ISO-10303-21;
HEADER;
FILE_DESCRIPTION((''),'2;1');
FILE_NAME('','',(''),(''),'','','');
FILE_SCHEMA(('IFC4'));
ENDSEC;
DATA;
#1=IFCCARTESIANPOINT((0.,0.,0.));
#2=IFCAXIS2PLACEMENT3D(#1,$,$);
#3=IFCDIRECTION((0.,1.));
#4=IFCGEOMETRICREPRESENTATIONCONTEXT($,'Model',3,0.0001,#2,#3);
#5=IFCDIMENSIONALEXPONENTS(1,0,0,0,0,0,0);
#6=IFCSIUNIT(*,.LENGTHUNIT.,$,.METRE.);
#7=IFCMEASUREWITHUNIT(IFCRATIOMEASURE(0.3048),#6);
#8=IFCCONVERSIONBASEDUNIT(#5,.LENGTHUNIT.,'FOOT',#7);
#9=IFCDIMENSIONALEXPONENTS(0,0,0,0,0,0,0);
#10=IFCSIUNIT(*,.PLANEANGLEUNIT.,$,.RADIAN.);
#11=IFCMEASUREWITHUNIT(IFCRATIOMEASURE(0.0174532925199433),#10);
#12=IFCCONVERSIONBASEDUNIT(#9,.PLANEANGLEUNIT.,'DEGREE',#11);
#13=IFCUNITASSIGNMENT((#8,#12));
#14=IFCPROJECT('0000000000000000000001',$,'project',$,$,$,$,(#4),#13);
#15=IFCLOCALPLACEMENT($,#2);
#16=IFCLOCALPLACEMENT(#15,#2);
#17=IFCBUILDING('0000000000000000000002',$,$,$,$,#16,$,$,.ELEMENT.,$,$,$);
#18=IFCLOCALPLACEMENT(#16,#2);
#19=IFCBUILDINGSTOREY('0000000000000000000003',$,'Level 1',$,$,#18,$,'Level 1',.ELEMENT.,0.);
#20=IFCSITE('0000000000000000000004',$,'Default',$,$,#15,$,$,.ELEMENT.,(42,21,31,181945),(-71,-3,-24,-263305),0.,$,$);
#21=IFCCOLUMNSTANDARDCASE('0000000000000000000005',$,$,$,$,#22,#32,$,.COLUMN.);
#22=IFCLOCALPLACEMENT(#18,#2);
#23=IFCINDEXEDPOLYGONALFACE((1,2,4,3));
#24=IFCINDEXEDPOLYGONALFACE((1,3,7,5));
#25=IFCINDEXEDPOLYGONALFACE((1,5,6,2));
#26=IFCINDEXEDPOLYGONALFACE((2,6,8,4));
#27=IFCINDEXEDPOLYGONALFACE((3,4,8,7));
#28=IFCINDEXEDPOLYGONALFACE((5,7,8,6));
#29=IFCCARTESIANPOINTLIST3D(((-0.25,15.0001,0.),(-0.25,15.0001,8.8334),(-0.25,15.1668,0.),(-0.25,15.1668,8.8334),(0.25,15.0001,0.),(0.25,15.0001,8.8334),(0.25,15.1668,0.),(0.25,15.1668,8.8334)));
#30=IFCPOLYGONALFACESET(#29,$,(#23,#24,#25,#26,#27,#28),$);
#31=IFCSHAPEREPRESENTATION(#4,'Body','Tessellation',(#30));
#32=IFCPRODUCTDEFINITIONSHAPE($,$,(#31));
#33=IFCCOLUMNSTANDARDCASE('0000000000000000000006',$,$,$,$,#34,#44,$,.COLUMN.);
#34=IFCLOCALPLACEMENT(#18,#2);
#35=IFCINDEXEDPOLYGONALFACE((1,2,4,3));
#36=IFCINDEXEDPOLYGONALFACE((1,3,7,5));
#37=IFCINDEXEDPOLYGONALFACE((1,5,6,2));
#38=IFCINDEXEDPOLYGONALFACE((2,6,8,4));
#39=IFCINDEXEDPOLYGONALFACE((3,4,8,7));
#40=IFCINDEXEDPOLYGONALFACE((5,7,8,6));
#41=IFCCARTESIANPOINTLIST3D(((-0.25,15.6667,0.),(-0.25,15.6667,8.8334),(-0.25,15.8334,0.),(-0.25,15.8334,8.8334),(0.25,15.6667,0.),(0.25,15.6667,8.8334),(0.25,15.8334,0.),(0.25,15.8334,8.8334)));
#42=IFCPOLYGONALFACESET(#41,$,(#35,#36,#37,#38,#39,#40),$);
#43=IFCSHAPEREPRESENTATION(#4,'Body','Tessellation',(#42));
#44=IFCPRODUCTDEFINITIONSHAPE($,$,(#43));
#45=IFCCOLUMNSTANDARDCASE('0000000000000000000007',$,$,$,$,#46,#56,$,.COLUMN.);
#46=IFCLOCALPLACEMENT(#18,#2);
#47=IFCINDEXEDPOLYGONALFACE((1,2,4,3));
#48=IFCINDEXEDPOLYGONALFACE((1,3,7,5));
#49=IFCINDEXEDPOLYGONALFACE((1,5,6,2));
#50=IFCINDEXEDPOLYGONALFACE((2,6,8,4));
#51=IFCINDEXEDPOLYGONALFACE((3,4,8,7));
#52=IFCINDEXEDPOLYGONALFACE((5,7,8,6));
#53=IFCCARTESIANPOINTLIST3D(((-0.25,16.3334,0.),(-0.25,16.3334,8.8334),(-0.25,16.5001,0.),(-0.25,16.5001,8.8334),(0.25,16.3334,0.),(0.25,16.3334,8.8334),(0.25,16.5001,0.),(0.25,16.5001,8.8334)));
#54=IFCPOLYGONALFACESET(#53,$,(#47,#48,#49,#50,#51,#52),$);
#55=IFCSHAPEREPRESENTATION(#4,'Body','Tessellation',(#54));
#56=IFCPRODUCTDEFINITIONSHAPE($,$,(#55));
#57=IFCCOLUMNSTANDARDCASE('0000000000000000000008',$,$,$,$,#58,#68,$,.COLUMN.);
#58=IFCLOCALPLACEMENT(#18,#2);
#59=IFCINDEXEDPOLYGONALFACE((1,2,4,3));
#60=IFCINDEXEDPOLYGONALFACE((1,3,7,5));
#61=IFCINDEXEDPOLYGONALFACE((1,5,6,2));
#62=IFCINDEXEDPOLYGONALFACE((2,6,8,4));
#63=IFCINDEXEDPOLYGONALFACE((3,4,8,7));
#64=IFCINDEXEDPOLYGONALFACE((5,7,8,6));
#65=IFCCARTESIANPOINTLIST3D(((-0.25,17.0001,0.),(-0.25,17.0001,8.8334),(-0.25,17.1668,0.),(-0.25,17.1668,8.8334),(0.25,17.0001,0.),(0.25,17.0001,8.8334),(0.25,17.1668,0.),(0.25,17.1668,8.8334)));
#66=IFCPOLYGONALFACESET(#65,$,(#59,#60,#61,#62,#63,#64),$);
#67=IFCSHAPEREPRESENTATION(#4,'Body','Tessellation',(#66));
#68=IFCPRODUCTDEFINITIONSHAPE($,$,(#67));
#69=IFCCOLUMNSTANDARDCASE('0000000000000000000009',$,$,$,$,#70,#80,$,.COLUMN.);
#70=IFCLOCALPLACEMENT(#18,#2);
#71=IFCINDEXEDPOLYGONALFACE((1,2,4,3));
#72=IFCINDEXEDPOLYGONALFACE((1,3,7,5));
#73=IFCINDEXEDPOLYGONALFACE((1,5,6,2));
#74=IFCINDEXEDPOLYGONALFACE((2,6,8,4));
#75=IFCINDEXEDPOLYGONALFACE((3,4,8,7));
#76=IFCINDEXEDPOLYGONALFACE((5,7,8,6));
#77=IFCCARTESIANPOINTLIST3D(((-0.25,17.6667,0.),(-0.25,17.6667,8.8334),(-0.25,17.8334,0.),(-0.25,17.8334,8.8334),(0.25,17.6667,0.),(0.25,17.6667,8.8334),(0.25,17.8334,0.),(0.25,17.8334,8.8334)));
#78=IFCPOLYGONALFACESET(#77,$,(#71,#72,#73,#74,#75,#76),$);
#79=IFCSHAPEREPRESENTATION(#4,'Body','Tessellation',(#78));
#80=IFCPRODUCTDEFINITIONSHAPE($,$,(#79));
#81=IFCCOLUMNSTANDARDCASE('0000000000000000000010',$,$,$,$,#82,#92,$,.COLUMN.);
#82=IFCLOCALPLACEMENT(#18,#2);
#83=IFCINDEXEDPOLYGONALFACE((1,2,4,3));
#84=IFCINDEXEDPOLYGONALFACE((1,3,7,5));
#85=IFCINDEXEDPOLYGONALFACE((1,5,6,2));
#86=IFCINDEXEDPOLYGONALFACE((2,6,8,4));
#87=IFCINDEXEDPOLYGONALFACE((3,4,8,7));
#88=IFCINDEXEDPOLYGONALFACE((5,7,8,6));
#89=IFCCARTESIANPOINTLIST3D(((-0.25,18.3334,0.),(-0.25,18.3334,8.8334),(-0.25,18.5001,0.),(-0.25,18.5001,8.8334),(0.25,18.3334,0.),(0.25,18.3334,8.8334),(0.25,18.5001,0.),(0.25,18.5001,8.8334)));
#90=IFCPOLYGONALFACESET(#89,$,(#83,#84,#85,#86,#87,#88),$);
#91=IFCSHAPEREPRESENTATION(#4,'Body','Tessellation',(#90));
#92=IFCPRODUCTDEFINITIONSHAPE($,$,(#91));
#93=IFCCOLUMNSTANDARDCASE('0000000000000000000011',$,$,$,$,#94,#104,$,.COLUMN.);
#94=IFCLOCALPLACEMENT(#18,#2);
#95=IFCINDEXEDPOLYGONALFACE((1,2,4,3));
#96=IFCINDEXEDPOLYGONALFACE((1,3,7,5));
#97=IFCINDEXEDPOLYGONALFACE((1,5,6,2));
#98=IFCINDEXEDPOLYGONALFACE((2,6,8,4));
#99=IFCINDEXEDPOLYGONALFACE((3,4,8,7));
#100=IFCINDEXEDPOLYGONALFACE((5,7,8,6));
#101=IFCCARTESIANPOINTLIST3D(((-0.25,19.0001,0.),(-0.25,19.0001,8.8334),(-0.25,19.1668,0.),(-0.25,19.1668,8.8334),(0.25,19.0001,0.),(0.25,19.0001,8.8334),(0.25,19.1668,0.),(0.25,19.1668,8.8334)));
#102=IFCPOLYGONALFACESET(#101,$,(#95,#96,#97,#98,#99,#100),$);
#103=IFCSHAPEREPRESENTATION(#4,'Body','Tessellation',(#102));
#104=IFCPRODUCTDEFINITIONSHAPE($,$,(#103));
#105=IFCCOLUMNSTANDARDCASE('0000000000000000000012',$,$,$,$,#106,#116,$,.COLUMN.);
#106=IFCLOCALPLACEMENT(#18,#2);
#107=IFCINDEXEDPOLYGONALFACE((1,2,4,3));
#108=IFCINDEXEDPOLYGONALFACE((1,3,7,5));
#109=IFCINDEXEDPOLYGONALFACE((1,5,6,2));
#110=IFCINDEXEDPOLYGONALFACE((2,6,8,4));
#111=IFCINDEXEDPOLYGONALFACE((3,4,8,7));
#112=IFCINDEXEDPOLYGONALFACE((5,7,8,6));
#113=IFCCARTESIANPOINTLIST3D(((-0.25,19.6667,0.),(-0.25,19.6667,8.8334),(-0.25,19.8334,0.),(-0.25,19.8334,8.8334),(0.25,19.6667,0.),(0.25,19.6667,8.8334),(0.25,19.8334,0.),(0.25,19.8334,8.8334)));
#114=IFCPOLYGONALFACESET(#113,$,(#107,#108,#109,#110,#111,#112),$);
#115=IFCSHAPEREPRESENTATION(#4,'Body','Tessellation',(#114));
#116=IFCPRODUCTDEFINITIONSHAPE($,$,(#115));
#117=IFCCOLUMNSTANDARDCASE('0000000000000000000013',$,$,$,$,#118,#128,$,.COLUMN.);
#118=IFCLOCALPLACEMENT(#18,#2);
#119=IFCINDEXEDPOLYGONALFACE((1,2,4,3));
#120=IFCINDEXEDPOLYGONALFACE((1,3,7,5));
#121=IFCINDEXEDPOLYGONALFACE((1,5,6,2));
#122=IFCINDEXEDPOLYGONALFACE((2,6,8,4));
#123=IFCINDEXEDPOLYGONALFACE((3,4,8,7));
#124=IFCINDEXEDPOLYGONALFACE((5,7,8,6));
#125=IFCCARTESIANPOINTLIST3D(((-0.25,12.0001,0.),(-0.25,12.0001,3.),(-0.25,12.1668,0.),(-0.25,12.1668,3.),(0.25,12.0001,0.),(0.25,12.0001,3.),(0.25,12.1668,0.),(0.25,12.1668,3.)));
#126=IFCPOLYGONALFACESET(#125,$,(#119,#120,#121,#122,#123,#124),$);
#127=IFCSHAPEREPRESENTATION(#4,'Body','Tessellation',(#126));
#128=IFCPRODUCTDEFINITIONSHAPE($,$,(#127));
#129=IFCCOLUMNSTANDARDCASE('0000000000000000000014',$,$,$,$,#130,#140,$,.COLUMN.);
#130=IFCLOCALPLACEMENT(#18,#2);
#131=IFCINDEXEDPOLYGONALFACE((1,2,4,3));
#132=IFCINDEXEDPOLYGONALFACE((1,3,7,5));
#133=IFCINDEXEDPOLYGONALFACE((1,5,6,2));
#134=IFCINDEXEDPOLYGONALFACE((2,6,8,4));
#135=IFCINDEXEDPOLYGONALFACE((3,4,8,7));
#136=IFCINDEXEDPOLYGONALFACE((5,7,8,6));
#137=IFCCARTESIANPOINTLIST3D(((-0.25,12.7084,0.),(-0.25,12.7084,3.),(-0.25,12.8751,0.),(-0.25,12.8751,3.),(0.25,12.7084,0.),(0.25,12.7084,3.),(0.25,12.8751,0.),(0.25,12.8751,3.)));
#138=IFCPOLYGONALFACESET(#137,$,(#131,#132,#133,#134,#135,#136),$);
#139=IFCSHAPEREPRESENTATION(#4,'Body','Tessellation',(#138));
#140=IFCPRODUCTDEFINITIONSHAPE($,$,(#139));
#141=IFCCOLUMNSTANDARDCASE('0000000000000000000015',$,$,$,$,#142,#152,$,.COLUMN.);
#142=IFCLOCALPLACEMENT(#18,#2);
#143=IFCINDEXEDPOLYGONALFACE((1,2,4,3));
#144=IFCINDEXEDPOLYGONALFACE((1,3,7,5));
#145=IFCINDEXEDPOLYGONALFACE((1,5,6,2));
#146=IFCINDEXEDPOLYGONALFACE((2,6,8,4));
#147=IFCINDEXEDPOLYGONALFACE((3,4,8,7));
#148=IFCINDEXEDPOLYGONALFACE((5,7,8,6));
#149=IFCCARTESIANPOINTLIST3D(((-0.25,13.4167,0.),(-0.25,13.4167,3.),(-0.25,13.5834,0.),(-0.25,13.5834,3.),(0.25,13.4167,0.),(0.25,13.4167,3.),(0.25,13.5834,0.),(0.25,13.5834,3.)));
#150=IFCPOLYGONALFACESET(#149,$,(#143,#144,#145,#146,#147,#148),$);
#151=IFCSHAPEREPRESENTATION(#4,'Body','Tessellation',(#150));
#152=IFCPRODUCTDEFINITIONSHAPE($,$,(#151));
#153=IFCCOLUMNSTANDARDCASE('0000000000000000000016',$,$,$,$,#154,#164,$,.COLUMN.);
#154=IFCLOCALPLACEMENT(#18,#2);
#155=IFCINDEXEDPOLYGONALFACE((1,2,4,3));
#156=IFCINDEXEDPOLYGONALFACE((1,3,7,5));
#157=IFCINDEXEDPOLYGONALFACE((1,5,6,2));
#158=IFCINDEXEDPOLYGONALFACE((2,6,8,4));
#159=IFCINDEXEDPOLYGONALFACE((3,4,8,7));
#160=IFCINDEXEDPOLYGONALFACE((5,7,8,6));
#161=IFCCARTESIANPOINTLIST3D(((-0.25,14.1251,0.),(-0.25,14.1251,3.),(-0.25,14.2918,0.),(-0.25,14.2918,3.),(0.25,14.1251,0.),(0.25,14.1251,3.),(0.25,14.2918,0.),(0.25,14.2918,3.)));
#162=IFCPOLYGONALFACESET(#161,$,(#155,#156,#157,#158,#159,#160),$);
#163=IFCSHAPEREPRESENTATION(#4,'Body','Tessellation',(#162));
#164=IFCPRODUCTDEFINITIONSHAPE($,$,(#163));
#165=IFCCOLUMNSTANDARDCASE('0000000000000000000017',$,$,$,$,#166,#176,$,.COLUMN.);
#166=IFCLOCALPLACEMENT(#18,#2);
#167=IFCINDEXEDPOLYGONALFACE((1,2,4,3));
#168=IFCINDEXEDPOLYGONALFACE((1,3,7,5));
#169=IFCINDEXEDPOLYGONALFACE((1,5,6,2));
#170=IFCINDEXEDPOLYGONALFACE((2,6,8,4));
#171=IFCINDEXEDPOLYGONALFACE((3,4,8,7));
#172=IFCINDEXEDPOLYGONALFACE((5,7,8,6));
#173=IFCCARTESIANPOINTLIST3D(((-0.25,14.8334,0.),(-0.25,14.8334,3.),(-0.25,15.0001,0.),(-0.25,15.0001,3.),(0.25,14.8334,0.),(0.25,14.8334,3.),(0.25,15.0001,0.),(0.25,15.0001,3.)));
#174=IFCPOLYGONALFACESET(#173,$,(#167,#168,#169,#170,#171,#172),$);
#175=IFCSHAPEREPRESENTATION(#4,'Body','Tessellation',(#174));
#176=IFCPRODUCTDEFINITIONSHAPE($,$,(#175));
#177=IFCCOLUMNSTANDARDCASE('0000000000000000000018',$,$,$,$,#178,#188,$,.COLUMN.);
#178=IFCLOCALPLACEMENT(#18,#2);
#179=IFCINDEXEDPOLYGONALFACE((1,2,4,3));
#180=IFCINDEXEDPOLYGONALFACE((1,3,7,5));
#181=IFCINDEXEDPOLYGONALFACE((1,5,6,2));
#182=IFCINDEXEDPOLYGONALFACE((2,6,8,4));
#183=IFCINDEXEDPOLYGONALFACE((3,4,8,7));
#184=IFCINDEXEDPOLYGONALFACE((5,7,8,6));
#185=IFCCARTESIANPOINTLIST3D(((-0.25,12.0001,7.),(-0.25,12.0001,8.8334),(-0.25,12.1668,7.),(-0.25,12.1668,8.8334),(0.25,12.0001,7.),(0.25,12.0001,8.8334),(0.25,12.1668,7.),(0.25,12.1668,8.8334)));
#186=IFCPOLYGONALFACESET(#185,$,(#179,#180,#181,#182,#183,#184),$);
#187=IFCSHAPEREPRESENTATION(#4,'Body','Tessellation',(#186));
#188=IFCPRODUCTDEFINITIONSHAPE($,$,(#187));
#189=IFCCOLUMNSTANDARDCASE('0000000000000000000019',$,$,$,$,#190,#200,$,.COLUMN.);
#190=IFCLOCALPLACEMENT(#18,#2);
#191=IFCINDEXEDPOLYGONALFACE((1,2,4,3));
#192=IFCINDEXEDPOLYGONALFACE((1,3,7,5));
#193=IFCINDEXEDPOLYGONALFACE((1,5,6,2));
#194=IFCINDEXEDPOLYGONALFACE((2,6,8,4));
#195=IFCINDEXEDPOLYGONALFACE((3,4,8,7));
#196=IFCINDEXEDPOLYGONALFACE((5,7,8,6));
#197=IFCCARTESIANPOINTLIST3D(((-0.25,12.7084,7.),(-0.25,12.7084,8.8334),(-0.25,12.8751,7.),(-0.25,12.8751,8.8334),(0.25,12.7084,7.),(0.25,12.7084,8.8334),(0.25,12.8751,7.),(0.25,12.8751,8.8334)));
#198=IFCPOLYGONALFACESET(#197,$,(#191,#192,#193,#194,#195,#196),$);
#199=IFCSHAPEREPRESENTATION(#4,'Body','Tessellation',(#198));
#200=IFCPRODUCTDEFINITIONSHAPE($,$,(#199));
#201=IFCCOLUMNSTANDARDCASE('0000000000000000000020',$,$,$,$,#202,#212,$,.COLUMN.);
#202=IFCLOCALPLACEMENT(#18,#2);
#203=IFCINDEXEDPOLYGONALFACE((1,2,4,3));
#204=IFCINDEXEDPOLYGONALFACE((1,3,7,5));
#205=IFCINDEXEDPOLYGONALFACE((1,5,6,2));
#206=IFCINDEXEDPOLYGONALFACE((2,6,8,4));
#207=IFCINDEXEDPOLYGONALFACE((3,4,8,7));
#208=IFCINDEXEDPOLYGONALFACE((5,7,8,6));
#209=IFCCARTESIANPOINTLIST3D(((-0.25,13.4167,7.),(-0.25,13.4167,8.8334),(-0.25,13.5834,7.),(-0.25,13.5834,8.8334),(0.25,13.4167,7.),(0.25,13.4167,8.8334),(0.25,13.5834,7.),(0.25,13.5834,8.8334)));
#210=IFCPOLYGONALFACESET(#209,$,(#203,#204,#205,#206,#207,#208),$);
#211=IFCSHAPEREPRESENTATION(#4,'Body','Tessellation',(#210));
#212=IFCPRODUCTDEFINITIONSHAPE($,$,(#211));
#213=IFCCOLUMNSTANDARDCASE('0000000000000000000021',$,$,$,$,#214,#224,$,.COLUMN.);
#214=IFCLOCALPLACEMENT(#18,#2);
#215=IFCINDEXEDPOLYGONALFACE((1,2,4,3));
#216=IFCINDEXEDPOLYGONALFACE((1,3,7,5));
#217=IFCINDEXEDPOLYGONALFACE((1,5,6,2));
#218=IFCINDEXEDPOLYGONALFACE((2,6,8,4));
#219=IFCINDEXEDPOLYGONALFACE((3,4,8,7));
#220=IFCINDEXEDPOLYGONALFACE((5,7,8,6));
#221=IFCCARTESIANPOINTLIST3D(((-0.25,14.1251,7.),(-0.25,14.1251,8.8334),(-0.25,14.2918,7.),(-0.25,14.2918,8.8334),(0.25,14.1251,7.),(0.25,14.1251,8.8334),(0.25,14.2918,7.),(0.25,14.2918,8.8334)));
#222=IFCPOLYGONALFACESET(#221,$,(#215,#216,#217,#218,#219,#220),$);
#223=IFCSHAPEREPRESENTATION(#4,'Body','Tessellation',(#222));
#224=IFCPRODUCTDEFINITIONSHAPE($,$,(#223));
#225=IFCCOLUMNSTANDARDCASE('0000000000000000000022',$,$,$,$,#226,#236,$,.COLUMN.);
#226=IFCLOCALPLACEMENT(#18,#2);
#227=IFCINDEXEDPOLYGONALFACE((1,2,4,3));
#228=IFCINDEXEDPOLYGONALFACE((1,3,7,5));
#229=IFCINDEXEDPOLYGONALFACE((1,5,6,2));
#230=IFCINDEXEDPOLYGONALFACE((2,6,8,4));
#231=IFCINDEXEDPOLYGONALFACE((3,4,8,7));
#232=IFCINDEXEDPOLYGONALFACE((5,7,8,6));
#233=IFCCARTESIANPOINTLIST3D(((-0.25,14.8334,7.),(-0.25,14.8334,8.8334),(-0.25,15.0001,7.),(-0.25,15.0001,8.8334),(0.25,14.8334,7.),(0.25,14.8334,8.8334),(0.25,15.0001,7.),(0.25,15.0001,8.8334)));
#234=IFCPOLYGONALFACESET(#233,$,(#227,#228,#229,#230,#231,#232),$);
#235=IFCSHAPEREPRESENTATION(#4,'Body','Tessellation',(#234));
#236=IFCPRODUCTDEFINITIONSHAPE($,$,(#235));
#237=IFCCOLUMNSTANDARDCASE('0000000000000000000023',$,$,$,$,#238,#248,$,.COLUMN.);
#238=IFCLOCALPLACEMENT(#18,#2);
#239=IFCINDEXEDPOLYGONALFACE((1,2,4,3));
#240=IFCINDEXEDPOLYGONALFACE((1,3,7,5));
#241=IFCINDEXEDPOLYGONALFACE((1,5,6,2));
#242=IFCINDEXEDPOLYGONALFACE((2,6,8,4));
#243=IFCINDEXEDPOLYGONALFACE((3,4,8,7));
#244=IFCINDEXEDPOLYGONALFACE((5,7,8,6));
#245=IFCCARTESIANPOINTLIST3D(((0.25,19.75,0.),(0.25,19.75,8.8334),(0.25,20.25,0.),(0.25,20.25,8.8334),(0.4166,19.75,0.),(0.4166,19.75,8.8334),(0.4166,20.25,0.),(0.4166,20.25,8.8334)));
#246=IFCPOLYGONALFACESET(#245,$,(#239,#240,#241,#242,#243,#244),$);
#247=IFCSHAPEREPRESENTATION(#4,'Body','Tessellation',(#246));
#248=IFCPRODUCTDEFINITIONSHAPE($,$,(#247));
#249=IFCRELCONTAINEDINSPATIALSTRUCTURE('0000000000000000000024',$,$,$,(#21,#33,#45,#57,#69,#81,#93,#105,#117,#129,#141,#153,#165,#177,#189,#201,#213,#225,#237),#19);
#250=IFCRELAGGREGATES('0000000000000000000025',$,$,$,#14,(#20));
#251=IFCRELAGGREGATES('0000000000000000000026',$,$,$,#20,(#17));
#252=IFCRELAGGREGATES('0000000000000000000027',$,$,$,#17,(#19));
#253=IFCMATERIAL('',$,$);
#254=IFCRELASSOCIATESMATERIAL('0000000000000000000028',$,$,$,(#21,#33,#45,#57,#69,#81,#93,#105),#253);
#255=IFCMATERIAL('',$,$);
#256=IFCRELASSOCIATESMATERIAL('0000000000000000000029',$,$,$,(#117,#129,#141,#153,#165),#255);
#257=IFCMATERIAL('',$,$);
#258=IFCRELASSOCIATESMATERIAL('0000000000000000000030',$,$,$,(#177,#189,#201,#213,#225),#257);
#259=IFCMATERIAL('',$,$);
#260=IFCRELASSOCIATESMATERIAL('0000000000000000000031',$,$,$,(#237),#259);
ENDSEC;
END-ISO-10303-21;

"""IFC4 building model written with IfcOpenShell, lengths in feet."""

from ifc_helpers import new_model, entity, si_unit, converted_unit, direction, frame, origin, place, context, project, spatial, rectangle, extrude, material, element, save


model = new_model("IFC4")

# Units and contexts
model_context = context("Model", 3, precision=0.0001, world=origin(), true_north=direction((0.0, 1.0)))
ifc_project = project(units=[converted_unit("LENGTHUNIT", "FOOT", entity("IfcRatioMeasure", 0.3048), si_unit("LENGTHUNIT", "METRE"), dimensions=[1, 0, 0, 0, 0, 0, 0]), converted_unit("PLANEANGLEUNIT", "DEGREE", entity("IfcRatioMeasure", 0.0174532925199433), si_unit("PLANEANGLEUNIT", "RADIAN"), dimensions=[0, 0, 0, 0, 0, 0, 0])], contexts=[model_context])

# Site, building, storey
site_placement = place(None, origin())
site = spatial("IfcSite", under=ifc_project, at=site_placement, Name="Default", CompositionType="ELEMENT", RefLatitude=(42, 21, 31, 181945), RefLongitude=(-71, -3, -24, -263305), RefElevation=0.0)
building_placement = place(site_placement, origin())
building = spatial("IfcBuilding", under=site, at=building_placement, CompositionType="ELEMENT")
storey_placement = place(building_placement, origin())
storey = spatial("IfcBuildingStorey", under=building, at=storey_placement, Name="Level 1", LongName="Level 1", CompositionType="ELEMENT", Elevation=0.0)

# Columns
ifc_material_1 = material(Name="")
placement_1 = place(storey_placement, frame((0.0, -0.25, 0.0), z_axis=(0.0, 0.0, 1.0), x_axis=(0.0, 1.0, 0.0)))
for number, where, z_axis, x_axis in (
    (1, (15.3334, 0.0, 0.0), (0.0, 0.0, 1.0), (1.0, 0.0, 0.0)),
    (2, (16.0, 0.0, 0.0), (0.0, 0.0, 1.0), (1.0, 0.0, 0.0)),
    (3, (16.6667, 0.0, 0.0), (0.0, 0.0, 1.0), (1.0, 0.0, 0.0)),
    (4, (17.3334, 0.0, 0.0), (0.0, 0.0, 1.0), (1.0, 0.0, 0.0)),
    (5, (18.0, 0.0, 0.0), (0.0, 0.0, 1.0), (1.0, 0.0, 0.0)),
    (6, (18.6667, 0.0, 0.0), (0.0, 0.0, 1.0), (1.0, 0.0, 0.0)),
    (7, (19.3334, 0.0, 0.0), (0.0, 0.0, 1.0), (1.0, 0.0, 0.0)),
    (8, (20.0, 0.0, 0.0), (0.0, 0.0, 1.0), (1.0, 0.0, 0.0)),
):
    element("IfcColumnStandardCase", number, at=place(placement_1, frame(where, z_axis=z_axis, x_axis=x_axis)), inside=storey, material=ifc_material_1, PredefinedType="COLUMN", context=model_context, shape_type="SweptSolid", body=[
        extrude(rectangle(XDim=0.1667, YDim=0.5), origin(), (0.0, 0.0, 1.0), 8.8334),
    ])
ifc_material_2 = material(Name="")
for number, where, z_axis, x_axis in (
    (9, (12.3334, 0.0, 0.0), (0.0, 0.0, 1.0), (1.0, 0.0, 0.0)),
    (10, (13.0417, 0.0, 0.0), (0.0, 0.0, 1.0), (1.0, 0.0, 0.0)),
    (11, (13.75, 0.0, 0.0), (0.0, 0.0, 1.0), (1.0, 0.0, 0.0)),
    (12, (14.4584, 0.0, 0.0), (0.0, 0.0, 1.0), (1.0, 0.0, 0.0)),
    (13, (15.1667, 0.0, 0.0), (0.0, 0.0, 1.0), (1.0, 0.0, 0.0)),
):
    element("IfcColumnStandardCase", number, at=place(placement_1, frame(where, z_axis=z_axis, x_axis=x_axis)), inside=storey, material=ifc_material_2, PredefinedType="COLUMN", context=model_context, shape_type="SweptSolid", body=[
        extrude(rectangle(XDim=0.1667, YDim=0.5), origin(), (0.0, 0.0, 1.0), 3.0),
    ])
ifc_material_3 = material(Name="")
for number, where, z_axis, x_axis in (
    (14, (12.3334, 0.0, 7.0), (0.0, 0.0, 1.0), (1.0, 0.0, 0.0)),
    (15, (13.0417, 0.0, 7.0), (0.0, 0.0, 1.0), (1.0, 0.0, 0.0)),
    (16, (13.75, 0.0, 7.0), (0.0, 0.0, 1.0), (1.0, 0.0, 0.0)),
    (17, (14.4584, 0.0, 7.0), (0.0, 0.0, 1.0), (1.0, 0.0, 0.0)),
    (18, (15.1667, 0.0, 7.0), (0.0, 0.0, 1.0), (1.0, 0.0, 0.0)),
):
    element("IfcColumnStandardCase", number, at=place(placement_1, frame(where, z_axis=z_axis, x_axis=x_axis)), inside=storey, material=ifc_material_3, PredefinedType="COLUMN", context=model_context, shape_type="SweptSolid", body=[
        extrude(rectangle(XDim=0.1667, YDim=0.5), origin(), (0.0, 0.0, 1.0), 1.8334),
    ])
ifc_material_4 = material(Name="")
placement_2 = place(storey_placement, frame((0.25, 20.0, 0.0)))
for number, where, z_axis, x_axis in (
    (19, (0.0833, 0.0, 0.0), (0.0, 0.0, 1.0), (1.0, 0.0, 0.0)),
):
    element("IfcColumnStandardCase", number, at=place(placement_2, frame(where, z_axis=z_axis, x_axis=x_axis)), inside=storey, material=ifc_material_4, PredefinedType="COLUMN", context=model_context, shape_type="SweptSolid", body=[
        extrude(rectangle(XDim=0.1667, YDim=0.5), origin(), (0.0, 0.0, 1.0), 8.8334),
    ])

save(model, "model.ifc")
